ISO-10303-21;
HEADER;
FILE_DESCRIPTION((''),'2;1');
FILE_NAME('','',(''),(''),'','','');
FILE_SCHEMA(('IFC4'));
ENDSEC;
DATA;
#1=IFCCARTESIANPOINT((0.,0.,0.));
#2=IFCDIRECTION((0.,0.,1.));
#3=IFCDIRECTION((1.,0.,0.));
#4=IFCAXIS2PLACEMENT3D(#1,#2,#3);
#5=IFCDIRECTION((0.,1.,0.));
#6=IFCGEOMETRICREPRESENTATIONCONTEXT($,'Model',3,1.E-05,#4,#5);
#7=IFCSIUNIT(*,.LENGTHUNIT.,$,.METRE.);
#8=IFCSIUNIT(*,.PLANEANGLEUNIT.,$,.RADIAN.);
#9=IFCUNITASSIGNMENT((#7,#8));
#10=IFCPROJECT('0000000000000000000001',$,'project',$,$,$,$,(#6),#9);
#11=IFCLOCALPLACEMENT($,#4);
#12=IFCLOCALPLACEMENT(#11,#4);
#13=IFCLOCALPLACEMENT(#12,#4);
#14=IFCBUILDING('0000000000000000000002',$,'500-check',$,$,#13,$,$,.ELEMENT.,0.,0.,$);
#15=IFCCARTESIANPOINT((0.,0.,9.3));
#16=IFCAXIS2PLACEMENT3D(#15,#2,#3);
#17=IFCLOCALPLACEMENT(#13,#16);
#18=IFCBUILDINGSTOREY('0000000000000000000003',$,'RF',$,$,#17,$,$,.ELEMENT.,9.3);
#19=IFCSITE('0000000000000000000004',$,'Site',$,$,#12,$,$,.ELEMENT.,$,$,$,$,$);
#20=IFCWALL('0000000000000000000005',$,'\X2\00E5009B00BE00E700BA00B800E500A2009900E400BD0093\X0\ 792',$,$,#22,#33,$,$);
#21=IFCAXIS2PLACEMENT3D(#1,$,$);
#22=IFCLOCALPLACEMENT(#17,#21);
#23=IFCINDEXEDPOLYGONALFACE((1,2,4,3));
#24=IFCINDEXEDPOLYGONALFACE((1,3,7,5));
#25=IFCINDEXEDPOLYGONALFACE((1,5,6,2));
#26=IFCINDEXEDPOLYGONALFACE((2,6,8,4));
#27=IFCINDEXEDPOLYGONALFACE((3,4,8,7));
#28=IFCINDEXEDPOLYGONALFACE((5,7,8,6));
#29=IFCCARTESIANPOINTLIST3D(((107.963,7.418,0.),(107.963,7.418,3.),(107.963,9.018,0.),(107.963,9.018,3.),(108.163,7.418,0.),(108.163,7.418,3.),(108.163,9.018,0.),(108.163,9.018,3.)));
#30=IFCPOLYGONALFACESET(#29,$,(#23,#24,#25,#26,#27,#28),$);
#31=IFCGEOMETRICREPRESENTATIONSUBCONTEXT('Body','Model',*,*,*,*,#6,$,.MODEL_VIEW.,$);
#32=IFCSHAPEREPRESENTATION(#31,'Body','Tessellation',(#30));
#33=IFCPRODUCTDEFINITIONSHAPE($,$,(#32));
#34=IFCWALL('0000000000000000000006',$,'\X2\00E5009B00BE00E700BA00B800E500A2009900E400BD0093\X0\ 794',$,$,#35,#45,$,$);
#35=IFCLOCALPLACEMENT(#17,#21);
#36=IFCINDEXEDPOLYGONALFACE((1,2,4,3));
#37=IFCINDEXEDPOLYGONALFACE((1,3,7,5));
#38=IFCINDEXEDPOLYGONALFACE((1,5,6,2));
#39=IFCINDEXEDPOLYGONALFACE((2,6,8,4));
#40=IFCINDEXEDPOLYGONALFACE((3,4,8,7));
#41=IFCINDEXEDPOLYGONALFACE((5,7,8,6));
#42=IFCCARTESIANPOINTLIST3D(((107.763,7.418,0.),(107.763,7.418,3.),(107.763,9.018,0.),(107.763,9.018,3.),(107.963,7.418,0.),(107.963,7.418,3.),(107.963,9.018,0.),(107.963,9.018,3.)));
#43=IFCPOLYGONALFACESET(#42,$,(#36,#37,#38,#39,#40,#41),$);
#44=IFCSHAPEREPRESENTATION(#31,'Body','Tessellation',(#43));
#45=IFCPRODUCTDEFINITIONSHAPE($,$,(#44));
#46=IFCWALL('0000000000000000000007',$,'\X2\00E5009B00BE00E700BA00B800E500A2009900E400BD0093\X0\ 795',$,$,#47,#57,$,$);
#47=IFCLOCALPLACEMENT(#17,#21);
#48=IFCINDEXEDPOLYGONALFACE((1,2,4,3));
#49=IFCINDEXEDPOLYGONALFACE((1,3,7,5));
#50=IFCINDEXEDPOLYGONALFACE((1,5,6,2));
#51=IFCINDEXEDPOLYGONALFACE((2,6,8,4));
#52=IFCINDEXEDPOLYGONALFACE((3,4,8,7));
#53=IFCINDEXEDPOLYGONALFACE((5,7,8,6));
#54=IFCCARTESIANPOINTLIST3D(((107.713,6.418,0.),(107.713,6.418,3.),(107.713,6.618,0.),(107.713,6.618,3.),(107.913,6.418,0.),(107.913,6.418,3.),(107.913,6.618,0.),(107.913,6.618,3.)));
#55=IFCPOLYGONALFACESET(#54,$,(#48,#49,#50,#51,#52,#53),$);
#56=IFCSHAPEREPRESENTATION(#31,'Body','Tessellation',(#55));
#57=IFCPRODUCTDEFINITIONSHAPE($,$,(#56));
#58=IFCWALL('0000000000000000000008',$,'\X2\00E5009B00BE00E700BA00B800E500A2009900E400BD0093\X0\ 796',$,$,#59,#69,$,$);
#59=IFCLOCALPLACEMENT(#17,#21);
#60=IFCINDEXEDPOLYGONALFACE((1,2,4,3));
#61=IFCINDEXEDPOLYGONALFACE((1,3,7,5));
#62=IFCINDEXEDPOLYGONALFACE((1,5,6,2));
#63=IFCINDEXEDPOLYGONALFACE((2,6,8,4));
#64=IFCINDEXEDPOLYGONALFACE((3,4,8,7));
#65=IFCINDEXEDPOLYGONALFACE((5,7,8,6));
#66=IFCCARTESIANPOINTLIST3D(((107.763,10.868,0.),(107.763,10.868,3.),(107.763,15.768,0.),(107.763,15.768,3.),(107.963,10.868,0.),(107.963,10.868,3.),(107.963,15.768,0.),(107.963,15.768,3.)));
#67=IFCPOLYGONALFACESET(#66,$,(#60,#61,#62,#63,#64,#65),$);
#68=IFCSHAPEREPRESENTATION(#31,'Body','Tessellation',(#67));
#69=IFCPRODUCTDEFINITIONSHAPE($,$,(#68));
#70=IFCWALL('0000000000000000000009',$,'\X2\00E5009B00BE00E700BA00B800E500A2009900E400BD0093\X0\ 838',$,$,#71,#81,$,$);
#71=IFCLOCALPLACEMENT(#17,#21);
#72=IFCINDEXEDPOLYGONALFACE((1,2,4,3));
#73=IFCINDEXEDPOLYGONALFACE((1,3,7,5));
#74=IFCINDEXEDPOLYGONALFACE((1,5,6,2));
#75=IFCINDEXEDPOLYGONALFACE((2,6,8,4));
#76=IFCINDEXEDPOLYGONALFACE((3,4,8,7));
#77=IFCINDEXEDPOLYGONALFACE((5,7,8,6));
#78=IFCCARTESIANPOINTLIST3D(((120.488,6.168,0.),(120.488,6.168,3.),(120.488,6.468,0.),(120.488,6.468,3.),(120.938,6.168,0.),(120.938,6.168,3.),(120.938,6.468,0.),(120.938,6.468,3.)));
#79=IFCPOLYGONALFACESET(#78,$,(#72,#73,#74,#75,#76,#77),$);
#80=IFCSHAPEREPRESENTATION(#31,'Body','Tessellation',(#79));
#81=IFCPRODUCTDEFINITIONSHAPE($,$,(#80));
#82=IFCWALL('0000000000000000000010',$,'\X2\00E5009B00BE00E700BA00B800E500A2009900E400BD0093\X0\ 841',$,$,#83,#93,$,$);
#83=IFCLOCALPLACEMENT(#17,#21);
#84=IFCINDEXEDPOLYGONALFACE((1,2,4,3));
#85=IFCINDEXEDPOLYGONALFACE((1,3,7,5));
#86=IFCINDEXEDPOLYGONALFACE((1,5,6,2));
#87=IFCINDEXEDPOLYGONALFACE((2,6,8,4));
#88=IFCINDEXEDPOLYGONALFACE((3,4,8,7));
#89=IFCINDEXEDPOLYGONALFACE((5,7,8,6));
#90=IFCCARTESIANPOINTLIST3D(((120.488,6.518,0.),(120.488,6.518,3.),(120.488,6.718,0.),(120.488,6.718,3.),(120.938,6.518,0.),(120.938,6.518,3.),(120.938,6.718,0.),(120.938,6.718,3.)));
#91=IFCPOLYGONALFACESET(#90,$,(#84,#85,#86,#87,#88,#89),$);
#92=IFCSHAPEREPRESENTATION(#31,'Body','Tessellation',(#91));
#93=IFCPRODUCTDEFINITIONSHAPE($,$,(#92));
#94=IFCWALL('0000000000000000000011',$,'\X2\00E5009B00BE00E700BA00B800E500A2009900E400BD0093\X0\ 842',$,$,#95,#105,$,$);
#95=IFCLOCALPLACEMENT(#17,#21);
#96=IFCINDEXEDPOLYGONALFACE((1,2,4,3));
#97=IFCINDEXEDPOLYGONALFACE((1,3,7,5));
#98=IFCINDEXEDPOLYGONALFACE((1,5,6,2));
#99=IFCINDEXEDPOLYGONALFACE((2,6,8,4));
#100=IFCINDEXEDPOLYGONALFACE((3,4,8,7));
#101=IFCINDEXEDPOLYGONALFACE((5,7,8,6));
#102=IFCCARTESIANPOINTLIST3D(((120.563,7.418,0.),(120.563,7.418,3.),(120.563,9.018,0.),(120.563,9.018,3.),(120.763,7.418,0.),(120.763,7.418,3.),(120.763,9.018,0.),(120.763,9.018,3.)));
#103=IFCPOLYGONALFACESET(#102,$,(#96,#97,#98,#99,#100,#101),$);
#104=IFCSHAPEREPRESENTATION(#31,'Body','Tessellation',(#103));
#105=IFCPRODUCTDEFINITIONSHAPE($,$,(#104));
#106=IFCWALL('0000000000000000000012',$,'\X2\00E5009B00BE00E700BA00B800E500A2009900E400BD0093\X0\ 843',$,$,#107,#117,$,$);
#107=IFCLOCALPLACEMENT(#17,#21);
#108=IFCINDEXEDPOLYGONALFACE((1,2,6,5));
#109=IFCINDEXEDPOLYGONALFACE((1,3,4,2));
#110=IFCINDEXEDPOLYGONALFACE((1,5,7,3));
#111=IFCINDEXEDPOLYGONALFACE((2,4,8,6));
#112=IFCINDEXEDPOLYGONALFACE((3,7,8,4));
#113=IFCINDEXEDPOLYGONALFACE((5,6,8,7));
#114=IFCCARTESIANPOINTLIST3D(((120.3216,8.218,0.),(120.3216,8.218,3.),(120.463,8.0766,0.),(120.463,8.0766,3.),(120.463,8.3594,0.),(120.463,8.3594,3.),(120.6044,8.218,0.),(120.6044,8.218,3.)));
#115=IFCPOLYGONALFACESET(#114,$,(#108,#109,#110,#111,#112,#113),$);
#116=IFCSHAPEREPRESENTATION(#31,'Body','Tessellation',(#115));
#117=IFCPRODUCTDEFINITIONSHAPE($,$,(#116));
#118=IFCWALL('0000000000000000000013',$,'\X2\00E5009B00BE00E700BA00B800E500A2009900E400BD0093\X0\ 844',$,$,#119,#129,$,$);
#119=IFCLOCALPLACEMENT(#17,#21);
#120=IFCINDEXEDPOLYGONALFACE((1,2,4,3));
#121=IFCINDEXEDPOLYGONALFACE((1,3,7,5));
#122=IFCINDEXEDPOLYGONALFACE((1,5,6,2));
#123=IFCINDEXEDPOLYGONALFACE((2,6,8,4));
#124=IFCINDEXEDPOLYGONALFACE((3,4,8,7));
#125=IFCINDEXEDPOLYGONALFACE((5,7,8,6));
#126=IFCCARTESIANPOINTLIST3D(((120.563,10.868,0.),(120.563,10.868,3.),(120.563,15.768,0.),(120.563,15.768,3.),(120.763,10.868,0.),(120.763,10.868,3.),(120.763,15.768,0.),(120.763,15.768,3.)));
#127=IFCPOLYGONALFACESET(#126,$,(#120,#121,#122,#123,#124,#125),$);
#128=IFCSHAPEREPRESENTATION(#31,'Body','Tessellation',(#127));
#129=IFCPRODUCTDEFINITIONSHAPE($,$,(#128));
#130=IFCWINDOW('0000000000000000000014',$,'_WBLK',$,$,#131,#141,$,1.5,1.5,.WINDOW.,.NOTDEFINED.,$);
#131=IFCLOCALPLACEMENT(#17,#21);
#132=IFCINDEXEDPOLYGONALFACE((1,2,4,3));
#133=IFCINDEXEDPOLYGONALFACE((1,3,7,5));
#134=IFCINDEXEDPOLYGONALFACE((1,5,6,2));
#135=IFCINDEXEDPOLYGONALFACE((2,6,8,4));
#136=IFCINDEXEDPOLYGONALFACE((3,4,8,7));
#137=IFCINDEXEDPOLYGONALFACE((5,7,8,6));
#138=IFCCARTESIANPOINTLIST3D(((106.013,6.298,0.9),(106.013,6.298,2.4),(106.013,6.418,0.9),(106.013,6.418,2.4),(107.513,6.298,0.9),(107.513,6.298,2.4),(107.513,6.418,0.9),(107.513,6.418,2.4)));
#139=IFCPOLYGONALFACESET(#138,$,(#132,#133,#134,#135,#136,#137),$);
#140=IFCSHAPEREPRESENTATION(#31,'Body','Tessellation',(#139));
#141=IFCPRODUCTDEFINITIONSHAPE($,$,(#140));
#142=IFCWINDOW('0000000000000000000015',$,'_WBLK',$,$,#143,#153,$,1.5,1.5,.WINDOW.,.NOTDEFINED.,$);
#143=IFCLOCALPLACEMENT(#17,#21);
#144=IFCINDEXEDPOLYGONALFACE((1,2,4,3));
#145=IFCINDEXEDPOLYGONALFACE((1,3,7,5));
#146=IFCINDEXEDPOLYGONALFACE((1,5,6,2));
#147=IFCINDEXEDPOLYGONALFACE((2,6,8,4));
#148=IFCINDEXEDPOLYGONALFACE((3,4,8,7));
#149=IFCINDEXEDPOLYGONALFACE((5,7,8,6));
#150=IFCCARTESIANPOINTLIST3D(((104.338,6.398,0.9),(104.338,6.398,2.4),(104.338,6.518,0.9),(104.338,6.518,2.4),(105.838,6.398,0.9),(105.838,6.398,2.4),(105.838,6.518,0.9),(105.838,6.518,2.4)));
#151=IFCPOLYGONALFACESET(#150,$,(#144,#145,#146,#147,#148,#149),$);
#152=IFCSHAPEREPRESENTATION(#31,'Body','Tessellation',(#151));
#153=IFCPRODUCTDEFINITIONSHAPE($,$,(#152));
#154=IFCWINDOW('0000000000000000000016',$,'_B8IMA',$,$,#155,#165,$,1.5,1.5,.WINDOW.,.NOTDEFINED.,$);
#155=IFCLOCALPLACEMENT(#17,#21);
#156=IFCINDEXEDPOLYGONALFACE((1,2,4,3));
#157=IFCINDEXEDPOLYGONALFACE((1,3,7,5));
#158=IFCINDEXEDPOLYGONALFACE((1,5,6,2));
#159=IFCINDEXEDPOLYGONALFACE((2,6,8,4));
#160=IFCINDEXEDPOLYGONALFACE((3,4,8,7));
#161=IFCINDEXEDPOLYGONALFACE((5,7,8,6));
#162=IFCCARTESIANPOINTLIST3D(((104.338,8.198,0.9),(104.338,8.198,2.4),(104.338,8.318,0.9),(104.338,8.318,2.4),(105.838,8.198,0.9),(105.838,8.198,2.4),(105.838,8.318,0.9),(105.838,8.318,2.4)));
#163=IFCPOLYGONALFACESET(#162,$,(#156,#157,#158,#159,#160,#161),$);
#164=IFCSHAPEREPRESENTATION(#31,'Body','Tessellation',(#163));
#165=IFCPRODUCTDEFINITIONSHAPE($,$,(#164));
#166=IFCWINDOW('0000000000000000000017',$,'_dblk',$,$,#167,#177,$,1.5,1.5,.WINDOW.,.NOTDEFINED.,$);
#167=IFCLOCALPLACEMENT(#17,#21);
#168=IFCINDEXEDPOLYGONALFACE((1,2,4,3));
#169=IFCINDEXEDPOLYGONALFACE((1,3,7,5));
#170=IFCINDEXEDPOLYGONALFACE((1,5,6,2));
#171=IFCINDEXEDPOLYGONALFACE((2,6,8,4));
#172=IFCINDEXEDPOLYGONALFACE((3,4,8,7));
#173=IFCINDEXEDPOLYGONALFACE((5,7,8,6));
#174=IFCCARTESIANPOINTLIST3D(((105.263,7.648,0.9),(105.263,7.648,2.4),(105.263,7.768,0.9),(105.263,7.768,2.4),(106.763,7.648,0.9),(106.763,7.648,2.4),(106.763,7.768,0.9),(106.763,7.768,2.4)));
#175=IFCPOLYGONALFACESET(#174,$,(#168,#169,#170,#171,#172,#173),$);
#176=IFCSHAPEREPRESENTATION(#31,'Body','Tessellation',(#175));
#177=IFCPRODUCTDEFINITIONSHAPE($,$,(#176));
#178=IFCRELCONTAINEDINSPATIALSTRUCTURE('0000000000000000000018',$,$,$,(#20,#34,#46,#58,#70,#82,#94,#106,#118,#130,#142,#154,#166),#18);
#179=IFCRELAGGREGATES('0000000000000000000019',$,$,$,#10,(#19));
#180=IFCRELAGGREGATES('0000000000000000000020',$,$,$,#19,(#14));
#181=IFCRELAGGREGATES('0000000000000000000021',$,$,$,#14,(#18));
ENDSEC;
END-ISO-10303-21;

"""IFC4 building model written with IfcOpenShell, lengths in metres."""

from ifc_helpers import new_model, si_unit, direction, frame, frame_2d, origin_with_axes, place, context, subcontext, project, spatial, rectangle, extrude, element, save


model = new_model("IFC4")

# Units and contexts
model_context = context("Model", 3, precision=1e-05, world=origin_with_axes(), true_north=direction((0.0, 1.0, 0.0)))
body_context = subcontext(model_context, "Body", "Model", "MODEL_VIEW")
ifc_project = project(units=[si_unit("LENGTHUNIT", "METRE"), si_unit("PLANEANGLEUNIT", "RADIAN")], contexts=[model_context])

# Site, building, storey
placement = place(None, origin_with_axes())
site_placement = place(placement, origin_with_axes())
site = spatial("IfcSite", under=ifc_project, at=site_placement, Name="Site", CompositionType="ELEMENT")
building_placement = place(site_placement, origin_with_axes())
building = spatial("IfcBuilding", under=site, at=building_placement, Name="500-check", CompositionType="ELEMENT", ElevationOfRefHeight=0.0, ElevationOfTerrain=0.0)
storey_placement = place(building_placement, frame((0.0, 0.0, 9.3), z_axis=(0.0, 0.0, 1.0), x_axis=(1.0, 0.0, 0.0)))
storey = spatial("IfcBuildingStorey", under=building, at=storey_placement, Name="RF", CompositionType="ELEMENT", Elevation=9.3)

# Walls
for number, where, z_axis, x_axis, name in (
    (1, (108.063, 8.218, 0.0), (0.0, 0.0, 1.0), (0.0, -1.0, 0.0), "å\u009b¾çº¸å¢\u0099ä½\u0093 792"),
    (2, (107.863, 8.218, 0.0), (0.0, 0.0, 1.0), (0.0, -1.0, 0.0), "å\u009b¾çº¸å¢\u0099ä½\u0093 794"),
):
    element("IfcWall", number, at=place(storey_placement, frame(where, z_axis=z_axis, x_axis=x_axis)), inside=storey, Name=name, context=body_context, shape_type="SweptSolid", body=[
        extrude(rectangle(XDim=1.6, YDim=0.2, at=frame_2d((0.0, 0.0), x_axis=(1.0, 0.0, 0.0))), frame((0.0, 0.0, 0.0), z_axis=(0.0, 0.0, 1.0)), (0.0, 0.0, 1.0), 3.0),
    ])
wall_1_placement = place(storey_placement, frame((107.813, 6.518, 0.0), z_axis=(0.0, 0.0, 1.0), x_axis=(0.0, -1.0, 0.0)))
element("IfcWall", 3, at=wall_1_placement, inside=storey, Name="å\u009b¾çº¸å¢\u0099ä½\u0093 795", context=body_context, shape_type="SweptSolid", body=[
    extrude(rectangle(XDim=0.2, YDim=0.2, at=frame_2d((0.0, 0.0), x_axis=(1.0, 0.0, 0.0))), frame((0.0, 0.0, 0.0), z_axis=(0.0, 0.0, 1.0)), (0.0, 0.0, 1.0), 3.0),
])
wall_2_placement = place(storey_placement, frame((107.863, 13.318, 0.0), z_axis=(0.0, 0.0, 1.0), x_axis=(0.0, -1.0, 0.0)))
element("IfcWall", 4, at=wall_2_placement, inside=storey, Name="å\u009b¾çº¸å¢\u0099ä½\u0093 796", context=body_context, shape_type="SweptSolid", body=[
    extrude(rectangle(XDim=4.9, YDim=0.2, at=frame_2d((0.0, 0.0), x_axis=(1.0, 0.0, 0.0))), frame((0.0, 0.0, 0.0), z_axis=(0.0, 0.0, 1.0)), (0.0, 0.0, 1.0), 3.0),
])
wall_3_placement = place(storey_placement, frame((120.713, 6.318, 0.0), z_axis=(0.0, 0.0, 1.0), x_axis=(1.0, 0.0, 0.0)))
element("IfcWall", 5, at=wall_3_placement, inside=storey, Name="å\u009b¾çº¸å¢\u0099ä½\u0093 838", context=body_context, shape_type="SweptSolid", body=[
    extrude(rectangle(XDim=0.45, YDim=0.3, at=frame_2d((0.0, 0.0), x_axis=(1.0, 0.0, 0.0))), frame((0.0, 0.0, 0.0), z_axis=(0.0, 0.0, 1.0)), (0.0, 0.0, 1.0), 3.0),
])
wall_4_placement = place(storey_placement, frame((120.713, 6.618, 0.0), z_axis=(0.0, 0.0, 1.0), x_axis=(1.0, 0.0, 0.0)))
element("IfcWall", 6, at=wall_4_placement, inside=storey, Name="å\u009b¾çº¸å¢\u0099ä½\u0093 841", context=body_context, shape_type="SweptSolid", body=[
    extrude(rectangle(XDim=0.45, YDim=0.2, at=frame_2d((0.0, 0.0), x_axis=(1.0, 0.0, 0.0))), frame((0.0, 0.0, 0.0), z_axis=(0.0, 0.0, 1.0)), (0.0, 0.0, 1.0), 3.0),
])
wall_5_placement = place(storey_placement, frame((120.663, 8.218, 0.0), z_axis=(0.0, 0.0, 1.0), x_axis=(0.0, -1.0, 0.0)))
element("IfcWall", 7, at=wall_5_placement, inside=storey, Name="å\u009b¾çº¸å¢\u0099ä½\u0093 842", context=body_context, shape_type="SweptSolid", body=[
    extrude(rectangle(XDim=1.6, YDim=0.2, at=frame_2d((0.0, 0.0), x_axis=(1.0, 0.0, 0.0))), frame((0.0, 0.0, 0.0), z_axis=(0.0, 0.0, 1.0)), (0.0, 0.0, 1.0), 3.0),
])
wall_6_placement = place(storey_placement, frame((120.463, 8.218, 0.0), z_axis=(0.0, 0.0, 1.0), x_axis=(0.707107, -0.707107, 0.0)))
element("IfcWall", 8, at=wall_6_placement, inside=storey, Name="å\u009b¾çº¸å¢\u0099ä½\u0093 843", context=body_context, shape_type="SweptSolid", body=[
    extrude(rectangle(XDim=0.2, YDim=0.2, at=frame_2d((0.0, 0.0), x_axis=(1.0, 0.0, 0.0))), frame((0.0, 0.0, 0.0), z_axis=(0.0, 0.0, 1.0)), (0.0, 0.0, 1.0), 3.0),
])
wall_7_placement = place(storey_placement, frame((120.663, 13.318, 0.0), z_axis=(0.0, 0.0, 1.0), x_axis=(0.0, -1.0, 0.0)))
element("IfcWall", 9, at=wall_7_placement, inside=storey, Name="å\u009b¾çº¸å¢\u0099ä½\u0093 844", context=body_context, shape_type="SweptSolid", body=[
    extrude(rectangle(XDim=4.9, YDim=0.2, at=frame_2d((0.0, 0.0), x_axis=(1.0, 0.0, 0.0))), frame((0.0, 0.0, 0.0), z_axis=(0.0, 0.0, 1.0)), (0.0, 0.0, 1.0), 3.0),
])

# Windows
for number, where, z_axis, x_axis, name in (
    (10, (106.763, 6.358, 0.9), (0.0, 0.0, 1.0), (1.0, 0.0, 0.0), "_WBLK"),
    (11, (105.088, 6.458, 0.9), (0.0, 0.0, 1.0), (1.0, 0.0, 0.0), "_WBLK"),
    (12, (105.088, 8.258, 0.9), (0.0, 0.0, 1.0), (1.0, 0.0, 0.0), "_B8IMA"),
    (13, (106.013, 7.708, 0.9), (0.0, 0.0, 1.0), (1.0, 0.0, 0.0), "_dblk"),
):
    element("IfcWindow", number, at=place(storey_placement, frame(where, z_axis=z_axis, x_axis=x_axis)), inside=storey, Name=name, OverallHeight=1.5, OverallWidth=1.5, PartitioningType="NOTDEFINED", PredefinedType="WINDOW", context=body_context, shape_type="SweptSolid", body=[
        extrude(rectangle(XDim=1.5, YDim=0.12, at=frame_2d((0.0, 0.0), x_axis=(1.0, 0.0, 0.0))), frame((0.0, 0.0, 0.0), z_axis=(0.0, 0.0, 1.0)), (0.0, 0.0, 1.0), 1.5),
    ])

save(model, "model.ifc")
